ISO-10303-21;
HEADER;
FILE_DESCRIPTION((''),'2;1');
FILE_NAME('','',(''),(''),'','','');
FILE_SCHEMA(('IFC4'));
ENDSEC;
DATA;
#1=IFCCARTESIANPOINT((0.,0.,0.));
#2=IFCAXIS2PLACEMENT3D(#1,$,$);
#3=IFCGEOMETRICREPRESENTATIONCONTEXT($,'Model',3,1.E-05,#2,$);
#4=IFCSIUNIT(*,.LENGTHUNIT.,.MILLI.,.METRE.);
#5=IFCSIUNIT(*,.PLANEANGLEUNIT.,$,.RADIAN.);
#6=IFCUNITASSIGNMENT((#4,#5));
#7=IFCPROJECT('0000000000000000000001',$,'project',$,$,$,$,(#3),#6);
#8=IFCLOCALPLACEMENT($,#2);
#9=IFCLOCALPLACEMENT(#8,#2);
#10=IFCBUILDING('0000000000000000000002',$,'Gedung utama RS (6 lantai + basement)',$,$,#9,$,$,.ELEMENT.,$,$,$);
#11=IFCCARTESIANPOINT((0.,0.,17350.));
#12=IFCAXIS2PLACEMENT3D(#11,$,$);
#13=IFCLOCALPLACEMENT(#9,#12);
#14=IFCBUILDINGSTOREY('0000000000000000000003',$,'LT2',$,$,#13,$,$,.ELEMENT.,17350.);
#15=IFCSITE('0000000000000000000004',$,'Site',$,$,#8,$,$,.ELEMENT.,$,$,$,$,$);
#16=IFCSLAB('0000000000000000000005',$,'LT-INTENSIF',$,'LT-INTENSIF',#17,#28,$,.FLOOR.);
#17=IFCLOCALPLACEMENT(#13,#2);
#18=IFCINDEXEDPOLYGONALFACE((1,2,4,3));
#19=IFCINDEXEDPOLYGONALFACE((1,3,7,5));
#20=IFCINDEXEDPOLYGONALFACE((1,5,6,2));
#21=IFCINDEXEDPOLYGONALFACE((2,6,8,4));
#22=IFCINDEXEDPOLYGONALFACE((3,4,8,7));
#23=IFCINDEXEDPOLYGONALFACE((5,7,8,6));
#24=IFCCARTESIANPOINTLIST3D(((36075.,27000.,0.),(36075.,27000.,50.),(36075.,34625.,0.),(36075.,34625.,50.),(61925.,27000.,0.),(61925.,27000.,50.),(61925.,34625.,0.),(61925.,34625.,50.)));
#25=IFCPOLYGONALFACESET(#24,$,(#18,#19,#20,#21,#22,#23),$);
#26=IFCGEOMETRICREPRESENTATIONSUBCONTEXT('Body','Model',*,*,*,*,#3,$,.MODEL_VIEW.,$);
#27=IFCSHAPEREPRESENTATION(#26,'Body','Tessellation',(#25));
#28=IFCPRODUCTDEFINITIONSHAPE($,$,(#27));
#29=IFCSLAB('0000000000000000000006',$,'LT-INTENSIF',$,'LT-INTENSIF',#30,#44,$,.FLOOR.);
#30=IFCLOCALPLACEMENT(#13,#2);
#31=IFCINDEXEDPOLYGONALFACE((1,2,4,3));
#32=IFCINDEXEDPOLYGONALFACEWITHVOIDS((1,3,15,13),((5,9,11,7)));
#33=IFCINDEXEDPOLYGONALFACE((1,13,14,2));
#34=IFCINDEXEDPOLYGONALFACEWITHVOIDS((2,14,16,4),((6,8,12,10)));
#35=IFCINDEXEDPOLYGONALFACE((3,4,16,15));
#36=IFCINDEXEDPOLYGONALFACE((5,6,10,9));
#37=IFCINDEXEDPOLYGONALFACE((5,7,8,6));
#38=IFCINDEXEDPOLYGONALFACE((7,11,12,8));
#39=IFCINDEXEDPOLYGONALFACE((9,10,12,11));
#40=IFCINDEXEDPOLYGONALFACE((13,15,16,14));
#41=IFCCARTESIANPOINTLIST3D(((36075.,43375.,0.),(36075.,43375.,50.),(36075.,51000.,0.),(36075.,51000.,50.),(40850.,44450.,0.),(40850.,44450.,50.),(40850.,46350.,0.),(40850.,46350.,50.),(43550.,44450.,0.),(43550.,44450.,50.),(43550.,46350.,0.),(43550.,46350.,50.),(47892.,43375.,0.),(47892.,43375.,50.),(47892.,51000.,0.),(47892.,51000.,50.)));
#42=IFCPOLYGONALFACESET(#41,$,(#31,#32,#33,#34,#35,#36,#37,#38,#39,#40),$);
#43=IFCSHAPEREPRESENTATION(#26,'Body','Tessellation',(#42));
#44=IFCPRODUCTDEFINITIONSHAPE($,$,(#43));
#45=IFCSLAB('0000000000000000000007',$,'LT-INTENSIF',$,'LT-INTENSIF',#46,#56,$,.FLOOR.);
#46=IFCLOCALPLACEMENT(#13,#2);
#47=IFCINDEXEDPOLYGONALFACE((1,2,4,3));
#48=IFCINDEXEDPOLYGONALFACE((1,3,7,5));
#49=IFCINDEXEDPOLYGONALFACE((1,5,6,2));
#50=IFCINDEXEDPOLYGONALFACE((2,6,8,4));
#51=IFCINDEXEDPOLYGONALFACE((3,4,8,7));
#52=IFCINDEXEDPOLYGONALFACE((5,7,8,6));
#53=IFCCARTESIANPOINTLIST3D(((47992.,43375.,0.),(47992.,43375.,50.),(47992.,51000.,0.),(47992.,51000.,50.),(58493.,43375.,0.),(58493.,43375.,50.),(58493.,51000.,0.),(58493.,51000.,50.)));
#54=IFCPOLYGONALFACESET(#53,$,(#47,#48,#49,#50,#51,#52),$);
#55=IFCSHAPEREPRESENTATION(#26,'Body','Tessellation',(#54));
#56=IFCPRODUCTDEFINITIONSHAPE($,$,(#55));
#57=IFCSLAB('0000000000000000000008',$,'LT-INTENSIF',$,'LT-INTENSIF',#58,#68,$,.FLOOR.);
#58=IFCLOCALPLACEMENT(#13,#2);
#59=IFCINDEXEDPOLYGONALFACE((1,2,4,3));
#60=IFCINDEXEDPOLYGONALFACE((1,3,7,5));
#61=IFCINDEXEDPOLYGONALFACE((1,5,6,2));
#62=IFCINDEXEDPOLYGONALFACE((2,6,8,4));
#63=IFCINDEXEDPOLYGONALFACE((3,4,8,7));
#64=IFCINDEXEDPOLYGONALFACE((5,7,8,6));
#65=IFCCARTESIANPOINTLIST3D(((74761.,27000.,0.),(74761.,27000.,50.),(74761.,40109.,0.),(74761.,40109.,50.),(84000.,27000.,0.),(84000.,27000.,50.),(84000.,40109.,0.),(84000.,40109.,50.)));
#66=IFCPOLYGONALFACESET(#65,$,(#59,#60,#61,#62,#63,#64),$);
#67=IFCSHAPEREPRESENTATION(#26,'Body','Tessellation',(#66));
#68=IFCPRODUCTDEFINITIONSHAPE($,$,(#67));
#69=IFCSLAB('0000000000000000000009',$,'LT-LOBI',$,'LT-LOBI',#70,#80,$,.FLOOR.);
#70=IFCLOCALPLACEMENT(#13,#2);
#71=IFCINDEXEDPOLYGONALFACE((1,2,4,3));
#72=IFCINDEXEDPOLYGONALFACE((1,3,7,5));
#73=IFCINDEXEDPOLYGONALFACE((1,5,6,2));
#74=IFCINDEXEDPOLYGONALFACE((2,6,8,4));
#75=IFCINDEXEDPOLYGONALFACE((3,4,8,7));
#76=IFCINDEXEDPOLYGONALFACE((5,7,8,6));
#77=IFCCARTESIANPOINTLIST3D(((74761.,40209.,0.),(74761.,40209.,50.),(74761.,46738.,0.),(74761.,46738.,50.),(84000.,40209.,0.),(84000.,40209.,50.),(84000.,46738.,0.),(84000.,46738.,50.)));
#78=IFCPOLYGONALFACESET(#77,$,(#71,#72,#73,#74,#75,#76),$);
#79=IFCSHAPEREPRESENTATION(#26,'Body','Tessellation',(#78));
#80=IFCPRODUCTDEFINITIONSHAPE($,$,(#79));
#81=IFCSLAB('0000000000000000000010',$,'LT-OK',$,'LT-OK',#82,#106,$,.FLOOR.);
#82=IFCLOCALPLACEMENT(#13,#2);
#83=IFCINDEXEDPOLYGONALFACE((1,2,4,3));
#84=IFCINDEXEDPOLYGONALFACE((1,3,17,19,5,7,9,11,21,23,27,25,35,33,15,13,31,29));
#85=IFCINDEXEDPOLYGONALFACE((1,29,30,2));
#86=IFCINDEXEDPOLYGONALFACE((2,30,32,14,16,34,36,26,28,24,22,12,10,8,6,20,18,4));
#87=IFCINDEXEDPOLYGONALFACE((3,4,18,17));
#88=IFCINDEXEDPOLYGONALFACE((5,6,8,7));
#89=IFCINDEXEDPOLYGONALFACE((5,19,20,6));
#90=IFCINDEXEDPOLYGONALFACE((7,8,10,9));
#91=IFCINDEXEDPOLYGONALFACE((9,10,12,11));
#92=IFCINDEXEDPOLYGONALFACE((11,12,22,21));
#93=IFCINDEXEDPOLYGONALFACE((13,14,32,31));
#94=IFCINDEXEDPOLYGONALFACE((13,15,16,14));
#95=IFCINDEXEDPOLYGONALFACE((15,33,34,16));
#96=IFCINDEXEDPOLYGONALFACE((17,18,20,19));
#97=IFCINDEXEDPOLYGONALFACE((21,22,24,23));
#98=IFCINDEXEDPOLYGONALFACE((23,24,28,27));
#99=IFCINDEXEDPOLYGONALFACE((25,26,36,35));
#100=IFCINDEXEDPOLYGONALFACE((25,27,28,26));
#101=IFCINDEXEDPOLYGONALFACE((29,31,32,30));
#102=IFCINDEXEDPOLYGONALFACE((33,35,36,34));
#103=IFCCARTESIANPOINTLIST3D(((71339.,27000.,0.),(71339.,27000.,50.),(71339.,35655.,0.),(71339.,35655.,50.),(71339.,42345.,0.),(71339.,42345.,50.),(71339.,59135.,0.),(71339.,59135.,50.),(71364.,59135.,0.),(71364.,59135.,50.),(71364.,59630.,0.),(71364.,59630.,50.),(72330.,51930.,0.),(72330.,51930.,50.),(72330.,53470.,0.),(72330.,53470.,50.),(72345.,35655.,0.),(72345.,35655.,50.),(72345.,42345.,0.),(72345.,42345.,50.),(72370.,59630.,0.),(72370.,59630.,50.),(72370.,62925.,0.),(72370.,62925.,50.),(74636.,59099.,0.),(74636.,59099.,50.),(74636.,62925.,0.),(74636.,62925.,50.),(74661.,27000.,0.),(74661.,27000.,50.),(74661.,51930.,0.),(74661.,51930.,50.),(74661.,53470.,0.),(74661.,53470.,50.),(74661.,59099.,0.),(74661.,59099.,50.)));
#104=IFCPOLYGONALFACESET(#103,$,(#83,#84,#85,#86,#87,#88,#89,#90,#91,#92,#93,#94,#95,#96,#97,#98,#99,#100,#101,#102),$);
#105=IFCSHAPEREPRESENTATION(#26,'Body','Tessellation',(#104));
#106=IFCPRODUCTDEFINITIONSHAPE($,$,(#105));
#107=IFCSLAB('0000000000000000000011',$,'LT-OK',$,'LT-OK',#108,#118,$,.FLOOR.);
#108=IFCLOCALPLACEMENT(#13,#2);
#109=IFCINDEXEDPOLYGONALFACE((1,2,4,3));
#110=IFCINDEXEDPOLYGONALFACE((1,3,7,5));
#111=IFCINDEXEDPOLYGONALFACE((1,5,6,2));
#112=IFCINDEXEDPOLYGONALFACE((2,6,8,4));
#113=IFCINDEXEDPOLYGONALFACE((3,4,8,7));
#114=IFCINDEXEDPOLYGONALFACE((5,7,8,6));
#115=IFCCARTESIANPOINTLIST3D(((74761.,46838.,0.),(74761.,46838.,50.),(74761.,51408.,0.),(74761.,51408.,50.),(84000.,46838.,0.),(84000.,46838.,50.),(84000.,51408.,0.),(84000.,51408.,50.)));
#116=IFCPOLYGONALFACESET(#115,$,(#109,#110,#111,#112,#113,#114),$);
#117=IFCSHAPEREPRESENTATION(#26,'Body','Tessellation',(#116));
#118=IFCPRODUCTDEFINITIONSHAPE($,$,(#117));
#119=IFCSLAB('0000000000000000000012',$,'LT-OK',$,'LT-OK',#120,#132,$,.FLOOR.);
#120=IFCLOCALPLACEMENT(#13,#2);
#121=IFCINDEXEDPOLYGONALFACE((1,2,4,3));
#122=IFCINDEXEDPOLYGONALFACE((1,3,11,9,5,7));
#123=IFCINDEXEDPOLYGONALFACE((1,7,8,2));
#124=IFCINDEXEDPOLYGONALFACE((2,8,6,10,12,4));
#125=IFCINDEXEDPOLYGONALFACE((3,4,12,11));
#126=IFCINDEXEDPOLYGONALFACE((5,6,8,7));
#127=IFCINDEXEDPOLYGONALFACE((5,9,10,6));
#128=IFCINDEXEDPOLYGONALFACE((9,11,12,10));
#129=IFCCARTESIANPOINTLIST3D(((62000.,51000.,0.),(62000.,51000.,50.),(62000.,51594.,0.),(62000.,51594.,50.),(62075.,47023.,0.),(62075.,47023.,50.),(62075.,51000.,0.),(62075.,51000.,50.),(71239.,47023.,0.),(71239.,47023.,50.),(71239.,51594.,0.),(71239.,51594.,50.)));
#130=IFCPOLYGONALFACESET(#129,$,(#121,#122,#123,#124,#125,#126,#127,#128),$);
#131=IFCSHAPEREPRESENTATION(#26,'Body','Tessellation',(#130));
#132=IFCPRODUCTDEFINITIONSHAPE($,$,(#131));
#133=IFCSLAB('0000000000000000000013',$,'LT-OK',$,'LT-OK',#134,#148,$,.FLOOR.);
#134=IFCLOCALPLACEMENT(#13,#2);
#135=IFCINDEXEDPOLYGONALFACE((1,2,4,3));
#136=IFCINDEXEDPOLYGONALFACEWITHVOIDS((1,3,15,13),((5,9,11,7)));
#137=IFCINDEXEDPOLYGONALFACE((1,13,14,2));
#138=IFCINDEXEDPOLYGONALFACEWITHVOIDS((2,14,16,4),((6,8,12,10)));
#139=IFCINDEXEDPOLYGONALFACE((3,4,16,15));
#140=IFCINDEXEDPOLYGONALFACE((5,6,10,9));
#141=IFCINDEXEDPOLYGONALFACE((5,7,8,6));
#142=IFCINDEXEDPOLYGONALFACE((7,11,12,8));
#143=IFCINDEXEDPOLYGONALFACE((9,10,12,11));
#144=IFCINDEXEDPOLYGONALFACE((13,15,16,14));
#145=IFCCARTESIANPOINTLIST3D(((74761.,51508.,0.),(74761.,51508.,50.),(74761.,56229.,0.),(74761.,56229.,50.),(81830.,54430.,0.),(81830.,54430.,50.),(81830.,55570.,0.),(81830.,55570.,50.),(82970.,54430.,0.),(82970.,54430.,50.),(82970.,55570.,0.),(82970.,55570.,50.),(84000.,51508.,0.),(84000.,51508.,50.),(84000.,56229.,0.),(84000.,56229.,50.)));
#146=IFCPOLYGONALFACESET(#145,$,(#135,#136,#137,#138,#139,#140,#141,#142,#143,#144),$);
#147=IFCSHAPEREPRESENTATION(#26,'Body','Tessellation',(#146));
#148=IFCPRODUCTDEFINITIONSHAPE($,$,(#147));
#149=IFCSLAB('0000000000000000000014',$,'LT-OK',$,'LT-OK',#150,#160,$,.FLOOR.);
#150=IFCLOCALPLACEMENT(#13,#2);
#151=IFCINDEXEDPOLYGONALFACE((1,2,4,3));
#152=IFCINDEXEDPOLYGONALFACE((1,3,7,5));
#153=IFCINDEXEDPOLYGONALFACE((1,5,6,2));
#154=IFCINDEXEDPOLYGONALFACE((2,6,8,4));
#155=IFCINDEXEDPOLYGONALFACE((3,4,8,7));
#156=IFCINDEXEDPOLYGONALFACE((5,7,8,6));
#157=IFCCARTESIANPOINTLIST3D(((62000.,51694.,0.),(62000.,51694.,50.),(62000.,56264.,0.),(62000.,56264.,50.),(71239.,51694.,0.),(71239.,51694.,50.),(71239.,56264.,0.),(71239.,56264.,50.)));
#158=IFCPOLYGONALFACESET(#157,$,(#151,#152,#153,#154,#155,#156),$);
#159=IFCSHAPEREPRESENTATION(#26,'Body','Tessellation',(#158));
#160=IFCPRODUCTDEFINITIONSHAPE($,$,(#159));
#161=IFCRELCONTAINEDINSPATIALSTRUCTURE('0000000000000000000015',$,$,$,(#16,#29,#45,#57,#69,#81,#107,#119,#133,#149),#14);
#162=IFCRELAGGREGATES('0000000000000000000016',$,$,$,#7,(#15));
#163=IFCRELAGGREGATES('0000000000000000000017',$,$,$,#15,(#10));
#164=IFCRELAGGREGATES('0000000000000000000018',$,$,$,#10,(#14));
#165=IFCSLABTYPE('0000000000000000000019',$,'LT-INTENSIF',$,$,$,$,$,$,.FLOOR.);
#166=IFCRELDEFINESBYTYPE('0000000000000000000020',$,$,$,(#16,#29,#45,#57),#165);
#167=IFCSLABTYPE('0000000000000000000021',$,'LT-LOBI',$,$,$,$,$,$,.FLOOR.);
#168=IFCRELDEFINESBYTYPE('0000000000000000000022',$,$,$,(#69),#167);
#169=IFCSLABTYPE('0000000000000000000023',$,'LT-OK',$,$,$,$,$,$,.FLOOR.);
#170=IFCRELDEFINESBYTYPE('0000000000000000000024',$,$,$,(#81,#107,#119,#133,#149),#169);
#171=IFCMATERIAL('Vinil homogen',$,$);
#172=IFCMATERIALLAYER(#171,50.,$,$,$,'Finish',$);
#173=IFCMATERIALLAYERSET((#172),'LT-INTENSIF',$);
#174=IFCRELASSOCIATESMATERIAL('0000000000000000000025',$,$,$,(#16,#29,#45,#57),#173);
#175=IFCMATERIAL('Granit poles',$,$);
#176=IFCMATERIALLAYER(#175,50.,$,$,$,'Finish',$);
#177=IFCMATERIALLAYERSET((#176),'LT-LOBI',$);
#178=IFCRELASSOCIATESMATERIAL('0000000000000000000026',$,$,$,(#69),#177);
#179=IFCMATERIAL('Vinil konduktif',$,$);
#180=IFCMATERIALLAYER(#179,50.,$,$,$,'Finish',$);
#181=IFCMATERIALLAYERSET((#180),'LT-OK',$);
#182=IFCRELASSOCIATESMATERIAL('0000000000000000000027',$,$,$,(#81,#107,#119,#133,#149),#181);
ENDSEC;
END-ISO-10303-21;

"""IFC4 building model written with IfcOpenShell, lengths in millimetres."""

from ifc_helpers import new_model, si_unit, frame, origin, place, context, subcontext, project, spatial, polyline, outline, extrude, material, layer, layer_set, layer_usage, type_object, element, save


model = new_model("IFC4")

# Units and contexts
model_context = context("Model", 3, precision=1e-05, world=origin())
body_context = subcontext(model_context, "Body", "Model", "MODEL_VIEW")
ifc_project = project(units=[si_unit("LENGTHUNIT", "METRE", prefix="MILLI"), si_unit("PLANEANGLEUNIT", "RADIAN")], contexts=[model_context])

# Site, building, storey
site_placement = place(None, origin())
site = spatial("IfcSite", under=ifc_project, at=site_placement, Name="Site", CompositionType="ELEMENT")
building_placement = place(site_placement, origin())
building = spatial("IfcBuilding", under=site, at=building_placement, Name="Gedung utama RS (6 lantai + basement)", CompositionType="ELEMENT")
storey_placement = place(building_placement, frame((0.0, 0.0, 17350.0)))
storey = spatial("IfcBuildingStorey", under=building, at=storey_placement, Name="LT2", CompositionType="ELEMENT", Elevation=17350.0)

# Slabs
ifc_material_1 = material(Name="Vinil homogen")
ifc_layer_1 = layer(ifc_material_1, 50.0, Category="Finish")
ifc_layer_set_1 = layer_set([ifc_layer_1], Name="LT-INTENSIF")
ifc_layer_usage_1 = layer_usage(ifc_layer_set_1, "AXIS3", "NEGATIVE", 50.0)
slab_type_1 = type_object("IfcSlabType", Name="LT-INTENSIF", PredefinedType="FLOOR")
slab_1_placement = place(storey_placement, origin())
element("IfcSlab", 1, at=slab_1_placement, inside=storey, type_object=slab_type_1, material=ifc_layer_usage_1, Name="LT-INTENSIF", ObjectType="LT-INTENSIF", PredefinedType="FLOOR", context=body_context, shape_type="SweptSolid", body=[
    extrude(outline(polyline([(36075.0, 27000.0), (61925.0, 27000.0), (61925.0, 34625.0), (36075.0, 34625.0), (36075.0, 27000.0)])), origin(), (0.0, 0.0, 1.0), 50.0),
])
slab_2_placement = place(storey_placement, origin())
element("IfcSlab", 2, at=slab_2_placement, inside=storey, type_object=slab_type_1, material=ifc_layer_usage_1, Name="LT-INTENSIF", ObjectType="LT-INTENSIF", PredefinedType="FLOOR", context=body_context, shape_type="SweptSolid", body=[
    extrude(outline(polyline([(36075.0, 43375.0), (47892.0, 43375.0), (47892.0, 51000.0), (36075.0, 51000.0), (36075.0, 43375.0)]), holes=[polyline([(40850.0, 44450.0), (40850.0, 46350.0), (43550.0, 46350.0), (43550.0, 44450.0), (40850.0, 44450.0)])]), origin(), (0.0, 0.0, 1.0), 50.0),
])
slab_3_placement = place(storey_placement, origin())
element("IfcSlab", 3, at=slab_3_placement, inside=storey, type_object=slab_type_1, material=ifc_layer_usage_1, Name="LT-INTENSIF", ObjectType="LT-INTENSIF", PredefinedType="FLOOR", context=body_context, shape_type="SweptSolid", body=[
    extrude(outline(polyline([(47992.0, 43375.0), (58493.0, 43375.0), (58493.0, 51000.0), (47992.0, 51000.0), (47992.0, 43375.0)])), origin(), (0.0, 0.0, 1.0), 50.0),
])
slab_4_placement = place(storey_placement, origin())
element("IfcSlab", 4, at=slab_4_placement, inside=storey, type_object=slab_type_1, material=ifc_layer_usage_1, Name="LT-INTENSIF", ObjectType="LT-INTENSIF", PredefinedType="FLOOR", context=body_context, shape_type="SweptSolid", body=[
    extrude(outline(polyline([(74761.0, 27000.0), (84000.0, 27000.0), (84000.0, 40109.0), (74761.0, 40109.0), (74761.0, 27000.0)])), origin(), (0.0, 0.0, 1.0), 50.0),
])
ifc_material_2 = material(Name="Granit poles")
ifc_layer_2 = layer(ifc_material_2, 50.0, Category="Finish")
ifc_layer_set_2 = layer_set([ifc_layer_2], Name="LT-LOBI")
ifc_layer_usage_2 = layer_usage(ifc_layer_set_2, "AXIS3", "NEGATIVE", 50.0)
slab_type_2 = type_object("IfcSlabType", Name="LT-LOBI", PredefinedType="FLOOR")
slab_5_placement = place(storey_placement, origin())
element("IfcSlab", 5, at=slab_5_placement, inside=storey, type_object=slab_type_2, material=ifc_layer_usage_2, Name="LT-LOBI", ObjectType="LT-LOBI", PredefinedType="FLOOR", context=body_context, shape_type="SweptSolid", body=[
    extrude(outline(polyline([(74761.0, 40209.0), (84000.0, 40209.0), (84000.0, 46738.0), (74761.0, 46738.0), (74761.0, 40209.0)])), origin(), (0.0, 0.0, 1.0), 50.0),
])
ifc_material_3 = material(Name="Vinil konduktif")
ifc_layer_3 = layer(ifc_material_3, 50.0, Category="Finish")
ifc_layer_set_3 = layer_set([ifc_layer_3], Name="LT-OK")
ifc_layer_usage_3 = layer_usage(ifc_layer_set_3, "AXIS3", "NEGATIVE", 50.0)
slab_type_3 = type_object("IfcSlabType", Name="LT-OK", PredefinedType="FLOOR")
slab_6_placement = place(storey_placement, origin())
element("IfcSlab", 6, at=slab_6_placement, inside=storey, type_object=slab_type_3, material=ifc_layer_usage_3, Name="LT-OK", ObjectType="LT-OK", PredefinedType="FLOOR", context=body_context, shape_type="SweptSolid", body=[
    extrude(outline(polyline([(71339.0, 27000.0), (74661.0, 27000.0), (74661.0, 51930.0), (72330.0, 51930.0), (72330.0, 53470.0), (74661.0, 53470.0), (74661.0, 59099.0), (74636.0, 59099.0), (74636.0, 62925.0), (72370.0, 62925.0), (72370.0, 59630.0), (71364.0, 59630.0), (71364.0, 59135.0), (71339.0, 59135.0), (71339.0, 42345.0), (72345.0, 42345.0), (72345.0, 35655.0), (71339.0, 35655.0), (71339.0, 27000.0)])), origin(), (0.0, 0.0, 1.0), 50.0),
])
slab_7_placement = place(storey_placement, origin())
element("IfcSlab", 7, at=slab_7_placement, inside=storey, type_object=slab_type_3, material=ifc_layer_usage_3, Name="LT-OK", ObjectType="LT-OK", PredefinedType="FLOOR", context=body_context, shape_type="SweptSolid", body=[
    extrude(outline(polyline([(74761.0, 46838.0), (84000.0, 46838.0), (84000.0, 51408.0), (74761.0, 51408.0), (74761.0, 46838.0)])), origin(), (0.0, 0.0, 1.0), 50.0),
])
slab_8_placement = place(storey_placement, origin())
element("IfcSlab", 8, at=slab_8_placement, inside=storey, type_object=slab_type_3, material=ifc_layer_usage_3, Name="LT-OK", ObjectType="LT-OK", PredefinedType="FLOOR", context=body_context, shape_type="SweptSolid", body=[
    extrude(outline(polyline([(62075.0, 47023.0), (71239.0, 47023.0), (71239.0, 51594.0), (62000.0, 51594.0), (62000.0, 51000.0), (62075.0, 51000.0), (62075.0, 47023.0)])), origin(), (0.0, 0.0, 1.0), 50.0),
])
slab_9_placement = place(storey_placement, origin())
element("IfcSlab", 9, at=slab_9_placement, inside=storey, type_object=slab_type_3, material=ifc_layer_usage_3, Name="LT-OK", ObjectType="LT-OK", PredefinedType="FLOOR", context=body_context, shape_type="SweptSolid", body=[
    extrude(outline(polyline([(74761.0, 51508.0), (84000.0, 51508.0), (84000.0, 56229.0), (74761.0, 56229.0), (74761.0, 51508.0)]), holes=[polyline([(81830.0, 54430.0), (81830.0, 55570.0), (82970.0, 55570.0), (82970.0, 54430.0), (81830.0, 54430.0)])]), origin(), (0.0, 0.0, 1.0), 50.0),
])
slab_10_placement = place(storey_placement, origin())
element("IfcSlab", 10, at=slab_10_placement, inside=storey, type_object=slab_type_3, material=ifc_layer_usage_3, Name="LT-OK", ObjectType="LT-OK", PredefinedType="FLOOR", context=body_context, shape_type="SweptSolid", body=[
    extrude(outline(polyline([(62000.0, 51694.0), (71239.0, 51694.0), (71239.0, 56264.0), (62000.0, 56264.0), (62000.0, 51694.0)])), origin(), (0.0, 0.0, 1.0), 50.0),
])

save(model, "model.ifc")
